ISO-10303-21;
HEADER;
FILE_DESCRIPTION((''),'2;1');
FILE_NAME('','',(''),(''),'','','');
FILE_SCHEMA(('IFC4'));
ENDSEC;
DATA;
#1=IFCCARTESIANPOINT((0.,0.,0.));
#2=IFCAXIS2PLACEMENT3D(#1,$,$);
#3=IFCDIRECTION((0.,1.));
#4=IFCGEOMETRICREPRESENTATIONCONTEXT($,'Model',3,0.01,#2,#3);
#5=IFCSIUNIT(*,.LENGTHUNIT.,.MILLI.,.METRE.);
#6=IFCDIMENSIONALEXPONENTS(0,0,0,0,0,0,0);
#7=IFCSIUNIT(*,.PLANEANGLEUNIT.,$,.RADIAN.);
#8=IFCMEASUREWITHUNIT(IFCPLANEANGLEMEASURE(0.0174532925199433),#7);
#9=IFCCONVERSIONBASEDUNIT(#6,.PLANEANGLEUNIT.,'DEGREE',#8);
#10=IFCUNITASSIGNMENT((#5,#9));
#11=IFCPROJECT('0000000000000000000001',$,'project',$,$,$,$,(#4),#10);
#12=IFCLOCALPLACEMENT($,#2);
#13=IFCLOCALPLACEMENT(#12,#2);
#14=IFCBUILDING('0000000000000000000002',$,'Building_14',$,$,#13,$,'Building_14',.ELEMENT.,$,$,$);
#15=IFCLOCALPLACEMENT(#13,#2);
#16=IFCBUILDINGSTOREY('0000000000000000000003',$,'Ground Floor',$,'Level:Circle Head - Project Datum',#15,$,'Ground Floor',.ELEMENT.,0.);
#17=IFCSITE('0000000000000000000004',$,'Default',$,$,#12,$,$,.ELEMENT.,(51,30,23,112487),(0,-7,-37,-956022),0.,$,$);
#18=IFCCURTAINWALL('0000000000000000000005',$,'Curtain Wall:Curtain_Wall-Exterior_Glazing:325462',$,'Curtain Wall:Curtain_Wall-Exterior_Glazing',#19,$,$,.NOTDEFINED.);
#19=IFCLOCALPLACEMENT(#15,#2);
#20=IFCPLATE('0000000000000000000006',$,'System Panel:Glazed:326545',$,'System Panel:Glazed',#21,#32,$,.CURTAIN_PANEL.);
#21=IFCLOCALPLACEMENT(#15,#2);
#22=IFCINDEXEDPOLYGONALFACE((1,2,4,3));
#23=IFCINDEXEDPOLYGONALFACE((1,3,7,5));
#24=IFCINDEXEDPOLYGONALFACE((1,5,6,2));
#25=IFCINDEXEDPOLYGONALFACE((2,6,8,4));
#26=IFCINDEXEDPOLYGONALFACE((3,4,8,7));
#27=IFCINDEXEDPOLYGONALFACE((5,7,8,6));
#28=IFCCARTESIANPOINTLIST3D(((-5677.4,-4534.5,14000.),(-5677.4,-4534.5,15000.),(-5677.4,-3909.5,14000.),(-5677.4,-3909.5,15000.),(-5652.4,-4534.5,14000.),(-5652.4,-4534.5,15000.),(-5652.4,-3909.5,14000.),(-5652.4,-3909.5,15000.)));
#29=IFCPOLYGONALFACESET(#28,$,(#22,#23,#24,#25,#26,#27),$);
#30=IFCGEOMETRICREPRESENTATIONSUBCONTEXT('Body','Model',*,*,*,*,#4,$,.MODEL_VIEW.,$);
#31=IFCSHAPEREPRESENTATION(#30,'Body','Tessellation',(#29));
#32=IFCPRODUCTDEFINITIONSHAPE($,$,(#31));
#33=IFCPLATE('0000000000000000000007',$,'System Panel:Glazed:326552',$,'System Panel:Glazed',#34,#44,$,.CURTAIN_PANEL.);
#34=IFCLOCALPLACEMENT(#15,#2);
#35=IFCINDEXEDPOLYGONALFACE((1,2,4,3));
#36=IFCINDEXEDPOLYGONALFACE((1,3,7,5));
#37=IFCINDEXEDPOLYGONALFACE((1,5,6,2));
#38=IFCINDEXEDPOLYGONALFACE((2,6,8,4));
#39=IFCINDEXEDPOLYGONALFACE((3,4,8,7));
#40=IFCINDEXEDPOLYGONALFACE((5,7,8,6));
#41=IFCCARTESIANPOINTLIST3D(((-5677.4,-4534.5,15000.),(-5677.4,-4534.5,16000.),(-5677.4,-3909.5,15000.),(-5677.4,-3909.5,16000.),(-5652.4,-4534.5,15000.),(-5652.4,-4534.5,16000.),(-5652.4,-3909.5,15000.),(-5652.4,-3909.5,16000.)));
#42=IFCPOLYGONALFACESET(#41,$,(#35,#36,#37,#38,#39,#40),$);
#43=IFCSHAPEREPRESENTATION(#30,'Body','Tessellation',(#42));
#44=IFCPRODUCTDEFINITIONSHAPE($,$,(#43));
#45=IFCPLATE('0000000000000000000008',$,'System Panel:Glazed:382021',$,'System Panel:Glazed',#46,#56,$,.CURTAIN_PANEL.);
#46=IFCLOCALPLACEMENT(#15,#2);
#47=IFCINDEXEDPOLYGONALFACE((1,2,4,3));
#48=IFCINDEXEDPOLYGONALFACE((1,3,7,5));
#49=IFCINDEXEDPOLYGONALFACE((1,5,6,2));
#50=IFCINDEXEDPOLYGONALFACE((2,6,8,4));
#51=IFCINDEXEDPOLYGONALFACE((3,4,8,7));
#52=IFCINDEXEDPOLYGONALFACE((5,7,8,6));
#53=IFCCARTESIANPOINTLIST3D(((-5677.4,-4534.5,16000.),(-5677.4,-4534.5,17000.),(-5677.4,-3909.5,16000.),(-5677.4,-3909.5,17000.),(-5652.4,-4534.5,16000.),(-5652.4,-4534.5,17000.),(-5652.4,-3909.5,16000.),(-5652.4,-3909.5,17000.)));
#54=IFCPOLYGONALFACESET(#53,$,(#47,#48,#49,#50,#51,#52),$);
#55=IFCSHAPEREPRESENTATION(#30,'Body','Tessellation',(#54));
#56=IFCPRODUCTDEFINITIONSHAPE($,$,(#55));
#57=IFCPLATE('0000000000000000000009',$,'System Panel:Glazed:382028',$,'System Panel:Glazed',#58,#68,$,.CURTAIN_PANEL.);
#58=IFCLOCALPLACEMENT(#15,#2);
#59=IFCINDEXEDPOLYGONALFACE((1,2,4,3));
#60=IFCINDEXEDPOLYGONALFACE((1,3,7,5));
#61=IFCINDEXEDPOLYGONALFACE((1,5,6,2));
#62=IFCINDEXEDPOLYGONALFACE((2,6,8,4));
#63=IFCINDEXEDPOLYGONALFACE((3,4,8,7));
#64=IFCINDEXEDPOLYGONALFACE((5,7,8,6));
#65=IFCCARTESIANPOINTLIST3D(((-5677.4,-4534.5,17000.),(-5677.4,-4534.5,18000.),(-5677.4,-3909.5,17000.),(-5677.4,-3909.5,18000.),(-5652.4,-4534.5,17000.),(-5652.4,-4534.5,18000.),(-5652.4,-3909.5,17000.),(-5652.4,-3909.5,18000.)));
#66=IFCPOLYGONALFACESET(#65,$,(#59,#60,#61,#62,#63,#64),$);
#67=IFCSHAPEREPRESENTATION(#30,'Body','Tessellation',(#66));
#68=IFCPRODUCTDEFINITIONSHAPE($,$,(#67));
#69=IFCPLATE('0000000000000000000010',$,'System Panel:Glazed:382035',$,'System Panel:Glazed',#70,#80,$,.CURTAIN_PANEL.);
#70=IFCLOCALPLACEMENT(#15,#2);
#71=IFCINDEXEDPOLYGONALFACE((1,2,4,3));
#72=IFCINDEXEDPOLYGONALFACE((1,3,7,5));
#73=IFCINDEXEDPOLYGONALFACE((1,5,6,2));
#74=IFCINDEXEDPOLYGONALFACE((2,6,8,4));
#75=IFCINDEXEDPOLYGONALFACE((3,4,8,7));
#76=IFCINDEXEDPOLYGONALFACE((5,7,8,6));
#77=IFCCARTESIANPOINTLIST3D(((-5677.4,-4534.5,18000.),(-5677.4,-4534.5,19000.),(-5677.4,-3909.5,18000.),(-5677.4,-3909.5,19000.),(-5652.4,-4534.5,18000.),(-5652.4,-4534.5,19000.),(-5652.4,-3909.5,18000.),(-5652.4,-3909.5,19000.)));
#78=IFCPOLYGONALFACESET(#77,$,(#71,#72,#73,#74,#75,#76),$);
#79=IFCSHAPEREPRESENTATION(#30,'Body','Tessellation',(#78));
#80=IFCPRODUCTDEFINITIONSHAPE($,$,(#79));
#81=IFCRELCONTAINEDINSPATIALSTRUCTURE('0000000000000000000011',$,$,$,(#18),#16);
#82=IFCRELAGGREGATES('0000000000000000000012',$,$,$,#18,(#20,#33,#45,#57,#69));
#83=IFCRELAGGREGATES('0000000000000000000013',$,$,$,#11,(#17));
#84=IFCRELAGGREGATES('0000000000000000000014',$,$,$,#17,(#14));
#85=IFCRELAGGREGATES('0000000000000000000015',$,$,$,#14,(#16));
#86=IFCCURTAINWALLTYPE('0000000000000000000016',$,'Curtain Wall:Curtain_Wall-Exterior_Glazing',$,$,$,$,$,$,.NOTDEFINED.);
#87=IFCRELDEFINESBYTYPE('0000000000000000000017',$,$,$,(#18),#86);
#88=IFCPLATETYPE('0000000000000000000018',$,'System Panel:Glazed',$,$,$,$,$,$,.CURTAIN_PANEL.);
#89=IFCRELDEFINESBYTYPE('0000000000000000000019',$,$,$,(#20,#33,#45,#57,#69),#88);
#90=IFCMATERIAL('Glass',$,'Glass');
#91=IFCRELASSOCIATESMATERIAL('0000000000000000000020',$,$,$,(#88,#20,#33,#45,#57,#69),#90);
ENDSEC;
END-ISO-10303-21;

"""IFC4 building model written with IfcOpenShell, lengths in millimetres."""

from ifc_helpers import new_model, entity, si_unit, converted_unit, direction, frame, origin, place, context, subcontext, project, spatial, indexed_curve, outline, extrude, source, transform, mapped, material, type_object, type_shapes, element, aggregate, save


model = new_model("IFC4")

# Units and contexts
model_context = context("Model", 3, precision=0.01, world=origin(), true_north=direction((0.0, 1.0)))
body_context = subcontext(model_context, "Body", "Model", "MODEL_VIEW")
ifc_project = project(units=[si_unit("LENGTHUNIT", "METRE", prefix="MILLI"), converted_unit("PLANEANGLEUNIT", "DEGREE", entity("IfcPlaneAngleMeasure", 0.0174532925199433), si_unit("PLANEANGLEUNIT", "RADIAN"), dimensions=[0, 0, 0, 0, 0, 0, 0])], contexts=[model_context])

# Site, building, storey
site_placement = place(None, origin())
site = spatial("IfcSite", under=ifc_project, at=site_placement, Name="Default", CompositionType="ELEMENT", RefLatitude=(51, 30, 23, 112487), RefLongitude=(0, -7, -37, -956022), RefElevation=0.0)
building_placement = place(site_placement, origin())
building = spatial("IfcBuilding", under=site, at=building_placement, Name="Building_14", LongName="Building_14", CompositionType="ELEMENT")
storey_placement = place(building_placement, origin())
storey = spatial("IfcBuildingStorey", under=building, at=storey_placement, Name="Ground Floor", ObjectType="Level:Circle Head - Project Datum", LongName="Ground Floor", CompositionType="ELEMENT", Elevation=0.0)

# Curtain wall
curtain_wall_type = type_object("IfcCurtainWallType", Name="Curtain Wall:Curtain_Wall-Exterior_Glazing", PredefinedType="NOTDEFINED")
curtain_wall_1_placement = place(storey_placement, origin())
curtain_wall_1 = element("IfcCurtainWall", 1, at=curtain_wall_1_placement, inside=storey, type_object=curtain_wall_type, Name="Curtain Wall:Curtain_Wall-Exterior_Glazing:325462", ObjectType="Curtain Wall:Curtain_Wall-Exterior_Glazing", PredefinedType="NOTDEFINED")
ifc_material = material(Name="Glass", Category="Glass")

# Plates
plate_type_1 = type_object("IfcPlateType", Name="System Panel:Glazed", PredefinedType="CURTAIN_PANEL", material=ifc_material)
shared_shape_1 = source(origin(), body_context, "Body", "SweptSolid", [
    extrude(outline(indexed_curve([(-12.5, -312.5), (12.5, -312.5), (12.5, 312.5), (-12.5, 312.5), (-12.5, -312.5)], self_intersect=False)), frame((0.0, -37.0, 0.0), z_axis=(0.0, 0.0, 1.0), x_axis=(0.0, 1.0, 0.0)), (0.0, 0.0, 1.0), 1000.0),
])
type_shapes(plate_type_1, [shared_shape_1])
plate_1_placement = place(curtain_wall_1_placement, frame((-5701.9, -4222.0, 14000.0), z_axis=(0.0, 0.0, 1.0), x_axis=(0.0, 1.0, 0.0)))
plate_1 = element("IfcPlate", 2, at=plate_1_placement, type_object=plate_type_1, material=ifc_material, Name="System Panel:Glazed:326545", ObjectType="System Panel:Glazed", PredefinedType="CURTAIN_PANEL", context=body_context, shape_type="MappedRepresentation", body=[
    mapped(shared_shape_1, transform((0.0, 0.0, 0.0), scale=1.0)),
])
plate_2_placement = place(curtain_wall_1_placement, frame((-5701.9, -4222.0, 15000.0), z_axis=(0.0, 0.0, 1.0), x_axis=(0.0, 1.0, 0.0)))
plate_2 = element("IfcPlate", 3, at=plate_2_placement, type_object=plate_type_1, material=ifc_material, Name="System Panel:Glazed:326552", ObjectType="System Panel:Glazed", PredefinedType="CURTAIN_PANEL", context=body_context, shape_type="MappedRepresentation", body=[
    mapped(shared_shape_1, transform((0.0, 0.0, 0.0), scale=1.0)),
])
plate_3_placement = place(curtain_wall_1_placement, frame((-5701.9, -4222.0, 16000.0), z_axis=(0.0, 0.0, 1.0), x_axis=(0.0, 1.0, 0.0)))
plate_3 = element("IfcPlate", 4, at=plate_3_placement, type_object=plate_type_1, material=ifc_material, Name="System Panel:Glazed:382021", ObjectType="System Panel:Glazed", PredefinedType="CURTAIN_PANEL", context=body_context, shape_type="MappedRepresentation", body=[
    mapped(shared_shape_1, transform((0.0, 0.0, 0.0), scale=1.0)),
])
plate_4_placement = place(curtain_wall_1_placement, frame((-5701.9, -4222.0, 17000.0), z_axis=(0.0, 0.0, 1.0), x_axis=(0.0, 1.0, 0.0)))
plate_4 = element("IfcPlate", 5, at=plate_4_placement, type_object=plate_type_1, material=ifc_material, Name="System Panel:Glazed:382028", ObjectType="System Panel:Glazed", PredefinedType="CURTAIN_PANEL", context=body_context, shape_type="MappedRepresentation", body=[
    mapped(shared_shape_1, transform((0.0, 0.0, 0.0), scale=1.0)),
])
plate_5_placement = place(curtain_wall_1_placement, frame((-5701.9, -4222.0, 18000.0), z_axis=(0.0, 0.0, 1.0), x_axis=(0.0, 1.0, 0.0)))
plate_5 = element("IfcPlate", 6, at=plate_5_placement, type_object=plate_type_1, material=ifc_material, Name="System Panel:Glazed:382035", ObjectType="System Panel:Glazed", PredefinedType="CURTAIN_PANEL", context=body_context, shape_type="MappedRepresentation", body=[
    mapped(shared_shape_1, transform((0.0, 0.0, 0.0), scale=1.0)),
])
aggregate(curtain_wall_1, [plate_1, plate_2, plate_3, plate_4, plate_5])

save(model, "model.ifc")
